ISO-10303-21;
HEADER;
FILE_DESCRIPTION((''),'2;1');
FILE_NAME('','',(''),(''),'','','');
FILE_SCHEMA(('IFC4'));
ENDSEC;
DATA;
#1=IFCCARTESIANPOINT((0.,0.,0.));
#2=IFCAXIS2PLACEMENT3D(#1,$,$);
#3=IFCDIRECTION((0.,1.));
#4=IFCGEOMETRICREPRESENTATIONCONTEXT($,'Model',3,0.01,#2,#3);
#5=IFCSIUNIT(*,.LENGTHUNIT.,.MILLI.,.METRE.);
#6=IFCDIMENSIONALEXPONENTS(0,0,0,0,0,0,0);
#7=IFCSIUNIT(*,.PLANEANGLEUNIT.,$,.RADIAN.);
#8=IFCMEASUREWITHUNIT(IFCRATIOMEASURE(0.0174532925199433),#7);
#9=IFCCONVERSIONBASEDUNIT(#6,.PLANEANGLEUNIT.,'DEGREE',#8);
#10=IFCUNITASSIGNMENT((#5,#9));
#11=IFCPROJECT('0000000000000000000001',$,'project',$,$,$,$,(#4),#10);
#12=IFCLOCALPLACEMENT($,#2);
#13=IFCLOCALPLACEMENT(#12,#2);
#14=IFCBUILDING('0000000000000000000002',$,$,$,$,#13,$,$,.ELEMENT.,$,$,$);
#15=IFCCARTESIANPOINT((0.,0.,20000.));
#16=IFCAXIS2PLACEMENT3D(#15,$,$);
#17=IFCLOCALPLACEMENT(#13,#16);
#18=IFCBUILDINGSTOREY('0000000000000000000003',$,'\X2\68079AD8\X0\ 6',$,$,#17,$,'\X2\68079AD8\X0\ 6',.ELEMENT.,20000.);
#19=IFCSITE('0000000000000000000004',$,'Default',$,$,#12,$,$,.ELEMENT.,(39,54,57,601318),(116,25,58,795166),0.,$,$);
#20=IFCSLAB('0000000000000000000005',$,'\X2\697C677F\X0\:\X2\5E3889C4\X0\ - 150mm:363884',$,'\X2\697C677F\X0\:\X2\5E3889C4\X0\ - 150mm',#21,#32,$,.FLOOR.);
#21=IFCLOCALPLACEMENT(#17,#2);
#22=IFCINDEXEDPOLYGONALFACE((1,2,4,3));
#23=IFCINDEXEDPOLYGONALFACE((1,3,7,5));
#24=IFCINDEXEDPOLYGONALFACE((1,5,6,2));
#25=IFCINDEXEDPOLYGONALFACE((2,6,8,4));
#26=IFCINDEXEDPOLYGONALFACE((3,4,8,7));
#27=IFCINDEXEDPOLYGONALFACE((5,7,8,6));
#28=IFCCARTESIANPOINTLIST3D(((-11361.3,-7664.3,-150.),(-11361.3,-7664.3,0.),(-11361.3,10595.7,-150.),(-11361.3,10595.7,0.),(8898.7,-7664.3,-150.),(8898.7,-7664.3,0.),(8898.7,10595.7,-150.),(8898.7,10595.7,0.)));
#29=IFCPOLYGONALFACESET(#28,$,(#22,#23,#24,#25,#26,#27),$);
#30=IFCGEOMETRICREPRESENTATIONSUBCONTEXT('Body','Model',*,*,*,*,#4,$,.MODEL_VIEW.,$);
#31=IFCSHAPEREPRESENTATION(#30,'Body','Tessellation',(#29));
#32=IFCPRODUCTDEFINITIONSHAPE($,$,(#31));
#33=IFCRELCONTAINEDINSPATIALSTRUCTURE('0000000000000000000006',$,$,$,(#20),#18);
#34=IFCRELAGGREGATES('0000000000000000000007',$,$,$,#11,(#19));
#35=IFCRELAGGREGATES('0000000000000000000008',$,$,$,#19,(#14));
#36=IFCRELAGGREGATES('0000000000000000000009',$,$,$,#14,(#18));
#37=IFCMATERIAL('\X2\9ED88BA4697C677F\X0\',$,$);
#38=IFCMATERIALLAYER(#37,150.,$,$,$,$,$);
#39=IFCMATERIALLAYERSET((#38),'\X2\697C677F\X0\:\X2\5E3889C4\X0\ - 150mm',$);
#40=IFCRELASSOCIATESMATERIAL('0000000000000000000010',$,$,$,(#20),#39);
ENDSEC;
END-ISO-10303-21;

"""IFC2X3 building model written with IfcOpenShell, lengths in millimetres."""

from ifc_helpers import new_model, entity, si_unit, converted_unit, direction, frame, frame_2d, origin, place, context, subcontext, project, spatial, rectangle, extrude, material, layer, layer_set, layer_usage, element, save


model = new_model("IFC2X3")

# Units and contexts
model_context = context("Model", 3, precision=0.01, world=origin(), true_north=direction((0.0, 1.0)))
body_context = subcontext(model_context, "Body", "Model", "MODEL_VIEW")
ifc_project = project(units=[si_unit("LENGTHUNIT", "METRE", prefix="MILLI"), converted_unit("PLANEANGLEUNIT", "DEGREE", entity("IfcRatioMeasure", 0.0174532925199433), si_unit("PLANEANGLEUNIT", "RADIAN"), dimensions=[0, 0, 0, 0, 0, 0, 0])], contexts=[model_context])

# Site, building, storey
site_placement = place(None, origin())
site = spatial("IfcSite", under=ifc_project, at=site_placement, Name="Default", CompositionType="ELEMENT", RefLatitude=(39, 54, 57, 601318), RefLongitude=(116, 25, 58, 795166), RefElevation=0.0)
building_placement = place(site_placement, origin())
building = spatial("IfcBuilding", under=site, at=building_placement, CompositionType="ELEMENT")
storey_placement = place(building_placement, frame((0.0, 0.0, 20000.0)))
storey = spatial("IfcBuildingStorey", under=building, at=storey_placement, Name="标高 6", LongName="标高 6", CompositionType="ELEMENT", Elevation=20000.0)

# Slab
ifc_material_1 = material(Name="默认楼板")
ifc_layer = layer(ifc_material_1, 150.0)
ifc_layer_set = layer_set([ifc_layer], Name="楼板:常规 - 150mm")
ifc_layer_usage = layer_usage(ifc_layer_set, "AXIS3", "POSITIVE", 0.0)
slab_placement = place(storey_placement, origin())
element("IfcSlab", 1, at=slab_placement, inside=storey, material=ifc_layer_usage, Name="楼板:常规 - 150mm:363884", ObjectType="楼板:常规 - 150mm", PredefinedType="FLOOR", context=body_context, shape_type="SweptSolid", body=[
    extrude(rectangle(XDim=18260.0, YDim=20260.0, at=frame_2d((0.0, 0.0), x_axis=(1.0, 0.0))), frame((-1231.3, 1465.7, 0.0), z_axis=(0.0, 0.0, -1.0), x_axis=(0.0, 1.0, 0.0)), (0.0, 0.0, 1.0), 150.0),
])

save(model, "model.ifc")
